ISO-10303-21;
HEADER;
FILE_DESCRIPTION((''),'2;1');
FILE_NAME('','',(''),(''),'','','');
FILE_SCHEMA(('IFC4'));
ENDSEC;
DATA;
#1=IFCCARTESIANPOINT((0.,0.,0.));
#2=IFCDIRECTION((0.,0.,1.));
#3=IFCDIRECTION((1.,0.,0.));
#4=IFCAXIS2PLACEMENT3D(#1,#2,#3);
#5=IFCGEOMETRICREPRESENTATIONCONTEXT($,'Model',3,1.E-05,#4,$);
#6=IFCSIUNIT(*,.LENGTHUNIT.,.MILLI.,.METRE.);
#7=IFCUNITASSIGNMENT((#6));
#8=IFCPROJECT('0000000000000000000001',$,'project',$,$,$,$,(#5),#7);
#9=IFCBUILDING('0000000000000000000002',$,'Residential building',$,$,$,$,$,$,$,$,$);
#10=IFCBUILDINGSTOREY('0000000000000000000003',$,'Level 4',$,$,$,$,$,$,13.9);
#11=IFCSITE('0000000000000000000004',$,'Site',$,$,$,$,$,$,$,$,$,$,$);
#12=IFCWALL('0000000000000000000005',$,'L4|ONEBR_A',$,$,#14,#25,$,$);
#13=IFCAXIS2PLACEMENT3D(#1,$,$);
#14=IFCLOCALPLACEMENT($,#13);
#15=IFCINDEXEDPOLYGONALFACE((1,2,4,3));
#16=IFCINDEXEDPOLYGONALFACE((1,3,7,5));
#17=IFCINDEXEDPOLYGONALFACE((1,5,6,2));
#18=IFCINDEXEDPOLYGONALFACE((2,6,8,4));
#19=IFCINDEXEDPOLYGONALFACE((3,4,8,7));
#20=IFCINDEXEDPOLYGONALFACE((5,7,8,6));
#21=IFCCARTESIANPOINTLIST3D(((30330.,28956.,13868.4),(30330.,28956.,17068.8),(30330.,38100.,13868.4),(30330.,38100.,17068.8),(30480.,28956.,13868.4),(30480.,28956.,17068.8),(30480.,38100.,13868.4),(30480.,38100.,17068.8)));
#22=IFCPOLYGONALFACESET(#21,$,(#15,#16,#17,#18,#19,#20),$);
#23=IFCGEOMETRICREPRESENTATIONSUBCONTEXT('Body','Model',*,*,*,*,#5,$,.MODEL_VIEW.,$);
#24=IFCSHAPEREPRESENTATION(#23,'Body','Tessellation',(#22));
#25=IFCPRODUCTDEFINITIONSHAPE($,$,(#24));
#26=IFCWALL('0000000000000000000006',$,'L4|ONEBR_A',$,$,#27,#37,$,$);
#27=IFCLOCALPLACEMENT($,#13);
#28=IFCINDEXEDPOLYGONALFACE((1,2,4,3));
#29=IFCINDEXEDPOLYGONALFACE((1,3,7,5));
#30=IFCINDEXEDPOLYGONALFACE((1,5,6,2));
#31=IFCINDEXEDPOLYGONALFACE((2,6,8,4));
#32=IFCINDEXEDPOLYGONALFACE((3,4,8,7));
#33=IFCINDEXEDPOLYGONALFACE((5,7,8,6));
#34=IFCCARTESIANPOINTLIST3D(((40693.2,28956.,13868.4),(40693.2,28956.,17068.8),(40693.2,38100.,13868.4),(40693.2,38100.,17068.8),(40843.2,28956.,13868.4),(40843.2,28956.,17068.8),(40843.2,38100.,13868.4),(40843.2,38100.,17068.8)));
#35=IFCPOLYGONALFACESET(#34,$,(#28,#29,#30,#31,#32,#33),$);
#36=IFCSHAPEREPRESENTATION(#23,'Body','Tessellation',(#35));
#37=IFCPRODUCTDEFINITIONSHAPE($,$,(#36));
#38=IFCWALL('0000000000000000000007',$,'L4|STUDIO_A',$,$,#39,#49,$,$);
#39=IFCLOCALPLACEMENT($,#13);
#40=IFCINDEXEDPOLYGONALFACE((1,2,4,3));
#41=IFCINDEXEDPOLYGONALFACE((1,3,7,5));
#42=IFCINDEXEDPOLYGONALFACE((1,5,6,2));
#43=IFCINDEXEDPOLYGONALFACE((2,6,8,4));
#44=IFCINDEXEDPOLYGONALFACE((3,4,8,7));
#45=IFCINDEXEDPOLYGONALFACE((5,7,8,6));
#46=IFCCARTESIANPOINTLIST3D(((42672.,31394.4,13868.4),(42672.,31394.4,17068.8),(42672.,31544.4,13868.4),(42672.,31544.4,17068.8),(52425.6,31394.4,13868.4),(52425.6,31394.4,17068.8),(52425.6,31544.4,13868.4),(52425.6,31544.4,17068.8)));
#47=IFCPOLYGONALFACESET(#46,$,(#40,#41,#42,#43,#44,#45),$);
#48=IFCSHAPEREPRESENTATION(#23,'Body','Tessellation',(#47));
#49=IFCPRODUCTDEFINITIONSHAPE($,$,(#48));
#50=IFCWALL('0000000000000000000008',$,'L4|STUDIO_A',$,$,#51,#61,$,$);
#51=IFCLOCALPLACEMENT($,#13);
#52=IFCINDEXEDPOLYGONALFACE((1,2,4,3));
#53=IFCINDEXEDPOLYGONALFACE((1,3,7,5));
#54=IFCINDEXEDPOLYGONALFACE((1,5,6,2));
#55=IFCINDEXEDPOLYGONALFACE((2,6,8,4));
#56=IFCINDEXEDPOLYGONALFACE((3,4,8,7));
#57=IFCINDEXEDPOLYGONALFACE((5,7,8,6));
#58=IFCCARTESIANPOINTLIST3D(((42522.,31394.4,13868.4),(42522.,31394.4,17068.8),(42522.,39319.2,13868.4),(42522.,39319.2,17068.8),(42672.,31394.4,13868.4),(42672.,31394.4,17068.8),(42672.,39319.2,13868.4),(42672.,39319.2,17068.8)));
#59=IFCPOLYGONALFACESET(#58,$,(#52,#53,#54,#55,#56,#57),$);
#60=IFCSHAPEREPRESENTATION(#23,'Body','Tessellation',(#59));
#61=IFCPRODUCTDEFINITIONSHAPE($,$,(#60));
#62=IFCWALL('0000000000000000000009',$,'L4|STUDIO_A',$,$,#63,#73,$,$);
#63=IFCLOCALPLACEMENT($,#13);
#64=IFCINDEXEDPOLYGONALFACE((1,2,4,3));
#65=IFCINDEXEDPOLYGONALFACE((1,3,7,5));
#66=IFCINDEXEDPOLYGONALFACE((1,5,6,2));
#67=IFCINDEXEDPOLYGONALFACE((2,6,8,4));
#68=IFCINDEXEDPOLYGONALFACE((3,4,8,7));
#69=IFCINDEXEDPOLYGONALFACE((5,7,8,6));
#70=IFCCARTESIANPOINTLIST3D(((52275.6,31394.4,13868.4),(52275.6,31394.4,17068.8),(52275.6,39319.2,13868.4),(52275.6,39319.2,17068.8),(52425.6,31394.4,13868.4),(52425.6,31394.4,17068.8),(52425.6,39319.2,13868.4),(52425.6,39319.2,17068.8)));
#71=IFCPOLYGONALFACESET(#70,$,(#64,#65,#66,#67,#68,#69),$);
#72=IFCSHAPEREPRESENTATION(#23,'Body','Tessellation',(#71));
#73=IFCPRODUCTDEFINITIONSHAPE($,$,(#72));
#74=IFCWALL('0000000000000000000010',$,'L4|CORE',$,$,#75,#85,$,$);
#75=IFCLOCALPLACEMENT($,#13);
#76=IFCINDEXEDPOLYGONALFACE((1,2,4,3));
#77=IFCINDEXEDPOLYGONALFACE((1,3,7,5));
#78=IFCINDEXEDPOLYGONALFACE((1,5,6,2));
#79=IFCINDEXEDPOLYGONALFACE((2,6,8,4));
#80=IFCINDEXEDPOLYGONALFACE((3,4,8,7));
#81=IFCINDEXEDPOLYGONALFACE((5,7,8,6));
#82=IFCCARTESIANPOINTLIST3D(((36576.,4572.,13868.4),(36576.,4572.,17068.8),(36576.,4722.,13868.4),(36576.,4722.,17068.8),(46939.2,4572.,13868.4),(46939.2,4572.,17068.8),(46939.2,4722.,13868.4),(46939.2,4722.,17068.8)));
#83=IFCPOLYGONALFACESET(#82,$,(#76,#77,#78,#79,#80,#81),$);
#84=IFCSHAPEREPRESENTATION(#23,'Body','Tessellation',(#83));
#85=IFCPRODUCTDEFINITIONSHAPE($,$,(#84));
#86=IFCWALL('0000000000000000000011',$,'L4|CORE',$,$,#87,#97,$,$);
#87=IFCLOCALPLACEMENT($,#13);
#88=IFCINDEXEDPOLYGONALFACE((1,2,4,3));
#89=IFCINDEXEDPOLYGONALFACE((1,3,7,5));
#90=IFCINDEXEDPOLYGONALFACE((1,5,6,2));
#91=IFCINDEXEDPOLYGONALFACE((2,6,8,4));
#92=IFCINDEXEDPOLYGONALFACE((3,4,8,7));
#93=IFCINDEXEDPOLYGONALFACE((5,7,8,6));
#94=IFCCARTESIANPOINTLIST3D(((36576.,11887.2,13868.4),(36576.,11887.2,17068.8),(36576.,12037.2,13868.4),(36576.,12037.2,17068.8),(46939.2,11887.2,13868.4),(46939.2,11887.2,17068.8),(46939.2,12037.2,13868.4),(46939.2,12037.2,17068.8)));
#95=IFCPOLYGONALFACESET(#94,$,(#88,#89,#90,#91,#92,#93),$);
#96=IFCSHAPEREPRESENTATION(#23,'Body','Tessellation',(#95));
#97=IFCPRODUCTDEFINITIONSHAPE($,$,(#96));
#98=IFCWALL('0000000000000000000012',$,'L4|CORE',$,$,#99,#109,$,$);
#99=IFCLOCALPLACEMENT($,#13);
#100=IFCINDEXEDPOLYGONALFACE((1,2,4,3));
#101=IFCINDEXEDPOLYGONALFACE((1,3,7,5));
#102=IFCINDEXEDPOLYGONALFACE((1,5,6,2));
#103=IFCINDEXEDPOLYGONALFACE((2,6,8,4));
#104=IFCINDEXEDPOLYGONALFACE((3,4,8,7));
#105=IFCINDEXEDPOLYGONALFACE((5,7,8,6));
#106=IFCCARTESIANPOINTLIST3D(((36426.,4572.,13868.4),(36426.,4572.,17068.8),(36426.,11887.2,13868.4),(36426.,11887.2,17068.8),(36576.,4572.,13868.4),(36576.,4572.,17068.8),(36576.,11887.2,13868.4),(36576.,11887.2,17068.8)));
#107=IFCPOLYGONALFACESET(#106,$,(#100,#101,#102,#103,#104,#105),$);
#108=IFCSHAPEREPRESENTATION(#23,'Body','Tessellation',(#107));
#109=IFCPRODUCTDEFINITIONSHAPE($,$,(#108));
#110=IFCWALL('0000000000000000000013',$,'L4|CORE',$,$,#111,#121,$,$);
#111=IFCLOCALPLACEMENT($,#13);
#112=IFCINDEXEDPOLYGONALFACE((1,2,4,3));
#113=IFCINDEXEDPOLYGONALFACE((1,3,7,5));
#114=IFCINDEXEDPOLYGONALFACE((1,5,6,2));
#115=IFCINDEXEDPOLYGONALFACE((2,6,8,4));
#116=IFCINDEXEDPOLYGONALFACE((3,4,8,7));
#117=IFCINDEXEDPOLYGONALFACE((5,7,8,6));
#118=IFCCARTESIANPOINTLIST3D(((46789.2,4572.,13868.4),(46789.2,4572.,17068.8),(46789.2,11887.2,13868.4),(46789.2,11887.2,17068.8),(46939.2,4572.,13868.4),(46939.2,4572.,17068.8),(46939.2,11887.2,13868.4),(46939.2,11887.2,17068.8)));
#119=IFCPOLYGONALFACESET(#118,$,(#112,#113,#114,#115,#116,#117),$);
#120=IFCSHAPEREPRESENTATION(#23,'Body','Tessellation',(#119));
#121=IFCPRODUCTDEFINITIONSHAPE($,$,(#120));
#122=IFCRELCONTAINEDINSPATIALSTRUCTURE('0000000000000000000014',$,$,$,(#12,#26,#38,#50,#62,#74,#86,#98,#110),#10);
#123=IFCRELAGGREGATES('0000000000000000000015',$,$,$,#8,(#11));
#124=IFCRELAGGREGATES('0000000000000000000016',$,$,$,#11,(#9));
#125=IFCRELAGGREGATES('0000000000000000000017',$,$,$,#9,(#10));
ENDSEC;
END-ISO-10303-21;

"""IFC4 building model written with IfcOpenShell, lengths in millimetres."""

from ifc_helpers import new_model, si_unit, frame, origin_with_axes, place, context, subcontext, project, spatial, indexed_curve, outline, extrude, element, save


model = new_model("IFC4")

# Units and contexts
model_context = context("Model", 3, precision=1e-05, world=origin_with_axes())
body_context = subcontext(model_context, "Body", "Model", "MODEL_VIEW")
ifc_project = project(units=[si_unit("LENGTHUNIT", "METRE", prefix="MILLI")], contexts=[model_context])

# Site, building, storey
site = spatial("IfcSite", under=ifc_project, Name="Site")
building = spatial("IfcBuilding", under=site, Name="Residential building")
storey = spatial("IfcBuildingStorey", under=building, Name="Level 4", Elevation=13.9)

# Walls
for number, where, z_axis, x_axis, name in (
    (1, (30480.0, 28956.0, 13868.4), (0.0, 0.0, 1.0), (0.0, 1.0, 0.0), "L4|ONEBR_A"),
    (2, (40843.2, 28956.0, 13868.4), (0.0, 0.0, 1.0), (0.0, 1.0, 0.0), "L4|ONEBR_A"),
):
    element("IfcWall", number, at=place(None, frame(where, z_axis=z_axis, x_axis=x_axis)), inside=storey, Name=name, context=body_context, shape_type="SweptSolid", body=[
        extrude(outline(indexed_curve([(0.0, 0.0), (0.0, 150.0), (9144.0, 150.0), (9144.0, 0.0), (0.0, 0.0)], self_intersect=False)), origin_with_axes(), (0.0, 0.0, 1.0), 3200.4),
    ])
wall_1_placement = place(None, frame((42672.0, 31394.4, 13868.4), z_axis=(0.0, 0.0, 1.0), x_axis=(1.0, 0.0, 0.0)))
element("IfcWall", 3, at=wall_1_placement, inside=storey, Name="L4|STUDIO_A", context=body_context, shape_type="SweptSolid", body=[
    extrude(outline(indexed_curve([(0.0, 0.0), (0.0, 150.0), (9753.6, 150.0), (9753.6, 0.0), (0.0, 0.0)], self_intersect=False)), origin_with_axes(), (0.0, 0.0, 1.0), 3200.4),
])
for number, where, z_axis, x_axis, name in (
    (4, (42672.0, 31394.4, 13868.4), (0.0, 0.0, 1.0), (0.0, 1.0, 0.0), "L4|STUDIO_A"),
    (5, (52425.6, 31394.4, 13868.4), (0.0, 0.0, 1.0), (0.0, 1.0, 0.0), "L4|STUDIO_A"),
):
    element("IfcWall", number, at=place(None, frame(where, z_axis=z_axis, x_axis=x_axis)), inside=storey, Name=name, context=body_context, shape_type="SweptSolid", body=[
        extrude(outline(indexed_curve([(0.0, 0.0), (0.0, 150.0), (7924.8, 150.0), (7924.8, 0.0), (0.0, 0.0)], self_intersect=False)), origin_with_axes(), (0.0, 0.0, 1.0), 3200.4),
    ])
for number, where, z_axis, x_axis, name in (
    (6, (36576.0, 4572.0, 13868.4), (0.0, 0.0, 1.0), (1.0, 0.0, 0.0), "L4|CORE"),
    (7, (36576.0, 11887.2, 13868.4), (0.0, 0.0, 1.0), (1.0, 0.0, 0.0), "L4|CORE"),
):
    element("IfcWall", number, at=place(None, frame(where, z_axis=z_axis, x_axis=x_axis)), inside=storey, Name=name, context=body_context, shape_type="SweptSolid", body=[
        extrude(outline(indexed_curve([(0.0, 0.0), (0.0, 150.0), (10363.2, 150.0), (10363.2, 0.0), (0.0, 0.0)], self_intersect=False)), origin_with_axes(), (0.0, 0.0, 1.0), 3200.4),
    ])
for number, where, z_axis, x_axis, name in (
    (8, (36576.0, 4572.0, 13868.4), (0.0, 0.0, 1.0), (0.0, 1.0, 0.0), "L4|CORE"),
    (9, (46939.2, 4572.0, 13868.4), (0.0, 0.0, 1.0), (0.0, 1.0, 0.0), "L4|CORE"),
):
    element("IfcWall", number, at=place(None, frame(where, z_axis=z_axis, x_axis=x_axis)), inside=storey, Name=name, context=body_context, shape_type="SweptSolid", body=[
        extrude(outline(indexed_curve([(0.0, 0.0), (0.0, 150.0), (7315.2, 150.0), (7315.2, 0.0), (0.0, 0.0)], self_intersect=False)), origin_with_axes(), (0.0, 0.0, 1.0), 3200.4),
    ])

save(model, "model.ifc")
